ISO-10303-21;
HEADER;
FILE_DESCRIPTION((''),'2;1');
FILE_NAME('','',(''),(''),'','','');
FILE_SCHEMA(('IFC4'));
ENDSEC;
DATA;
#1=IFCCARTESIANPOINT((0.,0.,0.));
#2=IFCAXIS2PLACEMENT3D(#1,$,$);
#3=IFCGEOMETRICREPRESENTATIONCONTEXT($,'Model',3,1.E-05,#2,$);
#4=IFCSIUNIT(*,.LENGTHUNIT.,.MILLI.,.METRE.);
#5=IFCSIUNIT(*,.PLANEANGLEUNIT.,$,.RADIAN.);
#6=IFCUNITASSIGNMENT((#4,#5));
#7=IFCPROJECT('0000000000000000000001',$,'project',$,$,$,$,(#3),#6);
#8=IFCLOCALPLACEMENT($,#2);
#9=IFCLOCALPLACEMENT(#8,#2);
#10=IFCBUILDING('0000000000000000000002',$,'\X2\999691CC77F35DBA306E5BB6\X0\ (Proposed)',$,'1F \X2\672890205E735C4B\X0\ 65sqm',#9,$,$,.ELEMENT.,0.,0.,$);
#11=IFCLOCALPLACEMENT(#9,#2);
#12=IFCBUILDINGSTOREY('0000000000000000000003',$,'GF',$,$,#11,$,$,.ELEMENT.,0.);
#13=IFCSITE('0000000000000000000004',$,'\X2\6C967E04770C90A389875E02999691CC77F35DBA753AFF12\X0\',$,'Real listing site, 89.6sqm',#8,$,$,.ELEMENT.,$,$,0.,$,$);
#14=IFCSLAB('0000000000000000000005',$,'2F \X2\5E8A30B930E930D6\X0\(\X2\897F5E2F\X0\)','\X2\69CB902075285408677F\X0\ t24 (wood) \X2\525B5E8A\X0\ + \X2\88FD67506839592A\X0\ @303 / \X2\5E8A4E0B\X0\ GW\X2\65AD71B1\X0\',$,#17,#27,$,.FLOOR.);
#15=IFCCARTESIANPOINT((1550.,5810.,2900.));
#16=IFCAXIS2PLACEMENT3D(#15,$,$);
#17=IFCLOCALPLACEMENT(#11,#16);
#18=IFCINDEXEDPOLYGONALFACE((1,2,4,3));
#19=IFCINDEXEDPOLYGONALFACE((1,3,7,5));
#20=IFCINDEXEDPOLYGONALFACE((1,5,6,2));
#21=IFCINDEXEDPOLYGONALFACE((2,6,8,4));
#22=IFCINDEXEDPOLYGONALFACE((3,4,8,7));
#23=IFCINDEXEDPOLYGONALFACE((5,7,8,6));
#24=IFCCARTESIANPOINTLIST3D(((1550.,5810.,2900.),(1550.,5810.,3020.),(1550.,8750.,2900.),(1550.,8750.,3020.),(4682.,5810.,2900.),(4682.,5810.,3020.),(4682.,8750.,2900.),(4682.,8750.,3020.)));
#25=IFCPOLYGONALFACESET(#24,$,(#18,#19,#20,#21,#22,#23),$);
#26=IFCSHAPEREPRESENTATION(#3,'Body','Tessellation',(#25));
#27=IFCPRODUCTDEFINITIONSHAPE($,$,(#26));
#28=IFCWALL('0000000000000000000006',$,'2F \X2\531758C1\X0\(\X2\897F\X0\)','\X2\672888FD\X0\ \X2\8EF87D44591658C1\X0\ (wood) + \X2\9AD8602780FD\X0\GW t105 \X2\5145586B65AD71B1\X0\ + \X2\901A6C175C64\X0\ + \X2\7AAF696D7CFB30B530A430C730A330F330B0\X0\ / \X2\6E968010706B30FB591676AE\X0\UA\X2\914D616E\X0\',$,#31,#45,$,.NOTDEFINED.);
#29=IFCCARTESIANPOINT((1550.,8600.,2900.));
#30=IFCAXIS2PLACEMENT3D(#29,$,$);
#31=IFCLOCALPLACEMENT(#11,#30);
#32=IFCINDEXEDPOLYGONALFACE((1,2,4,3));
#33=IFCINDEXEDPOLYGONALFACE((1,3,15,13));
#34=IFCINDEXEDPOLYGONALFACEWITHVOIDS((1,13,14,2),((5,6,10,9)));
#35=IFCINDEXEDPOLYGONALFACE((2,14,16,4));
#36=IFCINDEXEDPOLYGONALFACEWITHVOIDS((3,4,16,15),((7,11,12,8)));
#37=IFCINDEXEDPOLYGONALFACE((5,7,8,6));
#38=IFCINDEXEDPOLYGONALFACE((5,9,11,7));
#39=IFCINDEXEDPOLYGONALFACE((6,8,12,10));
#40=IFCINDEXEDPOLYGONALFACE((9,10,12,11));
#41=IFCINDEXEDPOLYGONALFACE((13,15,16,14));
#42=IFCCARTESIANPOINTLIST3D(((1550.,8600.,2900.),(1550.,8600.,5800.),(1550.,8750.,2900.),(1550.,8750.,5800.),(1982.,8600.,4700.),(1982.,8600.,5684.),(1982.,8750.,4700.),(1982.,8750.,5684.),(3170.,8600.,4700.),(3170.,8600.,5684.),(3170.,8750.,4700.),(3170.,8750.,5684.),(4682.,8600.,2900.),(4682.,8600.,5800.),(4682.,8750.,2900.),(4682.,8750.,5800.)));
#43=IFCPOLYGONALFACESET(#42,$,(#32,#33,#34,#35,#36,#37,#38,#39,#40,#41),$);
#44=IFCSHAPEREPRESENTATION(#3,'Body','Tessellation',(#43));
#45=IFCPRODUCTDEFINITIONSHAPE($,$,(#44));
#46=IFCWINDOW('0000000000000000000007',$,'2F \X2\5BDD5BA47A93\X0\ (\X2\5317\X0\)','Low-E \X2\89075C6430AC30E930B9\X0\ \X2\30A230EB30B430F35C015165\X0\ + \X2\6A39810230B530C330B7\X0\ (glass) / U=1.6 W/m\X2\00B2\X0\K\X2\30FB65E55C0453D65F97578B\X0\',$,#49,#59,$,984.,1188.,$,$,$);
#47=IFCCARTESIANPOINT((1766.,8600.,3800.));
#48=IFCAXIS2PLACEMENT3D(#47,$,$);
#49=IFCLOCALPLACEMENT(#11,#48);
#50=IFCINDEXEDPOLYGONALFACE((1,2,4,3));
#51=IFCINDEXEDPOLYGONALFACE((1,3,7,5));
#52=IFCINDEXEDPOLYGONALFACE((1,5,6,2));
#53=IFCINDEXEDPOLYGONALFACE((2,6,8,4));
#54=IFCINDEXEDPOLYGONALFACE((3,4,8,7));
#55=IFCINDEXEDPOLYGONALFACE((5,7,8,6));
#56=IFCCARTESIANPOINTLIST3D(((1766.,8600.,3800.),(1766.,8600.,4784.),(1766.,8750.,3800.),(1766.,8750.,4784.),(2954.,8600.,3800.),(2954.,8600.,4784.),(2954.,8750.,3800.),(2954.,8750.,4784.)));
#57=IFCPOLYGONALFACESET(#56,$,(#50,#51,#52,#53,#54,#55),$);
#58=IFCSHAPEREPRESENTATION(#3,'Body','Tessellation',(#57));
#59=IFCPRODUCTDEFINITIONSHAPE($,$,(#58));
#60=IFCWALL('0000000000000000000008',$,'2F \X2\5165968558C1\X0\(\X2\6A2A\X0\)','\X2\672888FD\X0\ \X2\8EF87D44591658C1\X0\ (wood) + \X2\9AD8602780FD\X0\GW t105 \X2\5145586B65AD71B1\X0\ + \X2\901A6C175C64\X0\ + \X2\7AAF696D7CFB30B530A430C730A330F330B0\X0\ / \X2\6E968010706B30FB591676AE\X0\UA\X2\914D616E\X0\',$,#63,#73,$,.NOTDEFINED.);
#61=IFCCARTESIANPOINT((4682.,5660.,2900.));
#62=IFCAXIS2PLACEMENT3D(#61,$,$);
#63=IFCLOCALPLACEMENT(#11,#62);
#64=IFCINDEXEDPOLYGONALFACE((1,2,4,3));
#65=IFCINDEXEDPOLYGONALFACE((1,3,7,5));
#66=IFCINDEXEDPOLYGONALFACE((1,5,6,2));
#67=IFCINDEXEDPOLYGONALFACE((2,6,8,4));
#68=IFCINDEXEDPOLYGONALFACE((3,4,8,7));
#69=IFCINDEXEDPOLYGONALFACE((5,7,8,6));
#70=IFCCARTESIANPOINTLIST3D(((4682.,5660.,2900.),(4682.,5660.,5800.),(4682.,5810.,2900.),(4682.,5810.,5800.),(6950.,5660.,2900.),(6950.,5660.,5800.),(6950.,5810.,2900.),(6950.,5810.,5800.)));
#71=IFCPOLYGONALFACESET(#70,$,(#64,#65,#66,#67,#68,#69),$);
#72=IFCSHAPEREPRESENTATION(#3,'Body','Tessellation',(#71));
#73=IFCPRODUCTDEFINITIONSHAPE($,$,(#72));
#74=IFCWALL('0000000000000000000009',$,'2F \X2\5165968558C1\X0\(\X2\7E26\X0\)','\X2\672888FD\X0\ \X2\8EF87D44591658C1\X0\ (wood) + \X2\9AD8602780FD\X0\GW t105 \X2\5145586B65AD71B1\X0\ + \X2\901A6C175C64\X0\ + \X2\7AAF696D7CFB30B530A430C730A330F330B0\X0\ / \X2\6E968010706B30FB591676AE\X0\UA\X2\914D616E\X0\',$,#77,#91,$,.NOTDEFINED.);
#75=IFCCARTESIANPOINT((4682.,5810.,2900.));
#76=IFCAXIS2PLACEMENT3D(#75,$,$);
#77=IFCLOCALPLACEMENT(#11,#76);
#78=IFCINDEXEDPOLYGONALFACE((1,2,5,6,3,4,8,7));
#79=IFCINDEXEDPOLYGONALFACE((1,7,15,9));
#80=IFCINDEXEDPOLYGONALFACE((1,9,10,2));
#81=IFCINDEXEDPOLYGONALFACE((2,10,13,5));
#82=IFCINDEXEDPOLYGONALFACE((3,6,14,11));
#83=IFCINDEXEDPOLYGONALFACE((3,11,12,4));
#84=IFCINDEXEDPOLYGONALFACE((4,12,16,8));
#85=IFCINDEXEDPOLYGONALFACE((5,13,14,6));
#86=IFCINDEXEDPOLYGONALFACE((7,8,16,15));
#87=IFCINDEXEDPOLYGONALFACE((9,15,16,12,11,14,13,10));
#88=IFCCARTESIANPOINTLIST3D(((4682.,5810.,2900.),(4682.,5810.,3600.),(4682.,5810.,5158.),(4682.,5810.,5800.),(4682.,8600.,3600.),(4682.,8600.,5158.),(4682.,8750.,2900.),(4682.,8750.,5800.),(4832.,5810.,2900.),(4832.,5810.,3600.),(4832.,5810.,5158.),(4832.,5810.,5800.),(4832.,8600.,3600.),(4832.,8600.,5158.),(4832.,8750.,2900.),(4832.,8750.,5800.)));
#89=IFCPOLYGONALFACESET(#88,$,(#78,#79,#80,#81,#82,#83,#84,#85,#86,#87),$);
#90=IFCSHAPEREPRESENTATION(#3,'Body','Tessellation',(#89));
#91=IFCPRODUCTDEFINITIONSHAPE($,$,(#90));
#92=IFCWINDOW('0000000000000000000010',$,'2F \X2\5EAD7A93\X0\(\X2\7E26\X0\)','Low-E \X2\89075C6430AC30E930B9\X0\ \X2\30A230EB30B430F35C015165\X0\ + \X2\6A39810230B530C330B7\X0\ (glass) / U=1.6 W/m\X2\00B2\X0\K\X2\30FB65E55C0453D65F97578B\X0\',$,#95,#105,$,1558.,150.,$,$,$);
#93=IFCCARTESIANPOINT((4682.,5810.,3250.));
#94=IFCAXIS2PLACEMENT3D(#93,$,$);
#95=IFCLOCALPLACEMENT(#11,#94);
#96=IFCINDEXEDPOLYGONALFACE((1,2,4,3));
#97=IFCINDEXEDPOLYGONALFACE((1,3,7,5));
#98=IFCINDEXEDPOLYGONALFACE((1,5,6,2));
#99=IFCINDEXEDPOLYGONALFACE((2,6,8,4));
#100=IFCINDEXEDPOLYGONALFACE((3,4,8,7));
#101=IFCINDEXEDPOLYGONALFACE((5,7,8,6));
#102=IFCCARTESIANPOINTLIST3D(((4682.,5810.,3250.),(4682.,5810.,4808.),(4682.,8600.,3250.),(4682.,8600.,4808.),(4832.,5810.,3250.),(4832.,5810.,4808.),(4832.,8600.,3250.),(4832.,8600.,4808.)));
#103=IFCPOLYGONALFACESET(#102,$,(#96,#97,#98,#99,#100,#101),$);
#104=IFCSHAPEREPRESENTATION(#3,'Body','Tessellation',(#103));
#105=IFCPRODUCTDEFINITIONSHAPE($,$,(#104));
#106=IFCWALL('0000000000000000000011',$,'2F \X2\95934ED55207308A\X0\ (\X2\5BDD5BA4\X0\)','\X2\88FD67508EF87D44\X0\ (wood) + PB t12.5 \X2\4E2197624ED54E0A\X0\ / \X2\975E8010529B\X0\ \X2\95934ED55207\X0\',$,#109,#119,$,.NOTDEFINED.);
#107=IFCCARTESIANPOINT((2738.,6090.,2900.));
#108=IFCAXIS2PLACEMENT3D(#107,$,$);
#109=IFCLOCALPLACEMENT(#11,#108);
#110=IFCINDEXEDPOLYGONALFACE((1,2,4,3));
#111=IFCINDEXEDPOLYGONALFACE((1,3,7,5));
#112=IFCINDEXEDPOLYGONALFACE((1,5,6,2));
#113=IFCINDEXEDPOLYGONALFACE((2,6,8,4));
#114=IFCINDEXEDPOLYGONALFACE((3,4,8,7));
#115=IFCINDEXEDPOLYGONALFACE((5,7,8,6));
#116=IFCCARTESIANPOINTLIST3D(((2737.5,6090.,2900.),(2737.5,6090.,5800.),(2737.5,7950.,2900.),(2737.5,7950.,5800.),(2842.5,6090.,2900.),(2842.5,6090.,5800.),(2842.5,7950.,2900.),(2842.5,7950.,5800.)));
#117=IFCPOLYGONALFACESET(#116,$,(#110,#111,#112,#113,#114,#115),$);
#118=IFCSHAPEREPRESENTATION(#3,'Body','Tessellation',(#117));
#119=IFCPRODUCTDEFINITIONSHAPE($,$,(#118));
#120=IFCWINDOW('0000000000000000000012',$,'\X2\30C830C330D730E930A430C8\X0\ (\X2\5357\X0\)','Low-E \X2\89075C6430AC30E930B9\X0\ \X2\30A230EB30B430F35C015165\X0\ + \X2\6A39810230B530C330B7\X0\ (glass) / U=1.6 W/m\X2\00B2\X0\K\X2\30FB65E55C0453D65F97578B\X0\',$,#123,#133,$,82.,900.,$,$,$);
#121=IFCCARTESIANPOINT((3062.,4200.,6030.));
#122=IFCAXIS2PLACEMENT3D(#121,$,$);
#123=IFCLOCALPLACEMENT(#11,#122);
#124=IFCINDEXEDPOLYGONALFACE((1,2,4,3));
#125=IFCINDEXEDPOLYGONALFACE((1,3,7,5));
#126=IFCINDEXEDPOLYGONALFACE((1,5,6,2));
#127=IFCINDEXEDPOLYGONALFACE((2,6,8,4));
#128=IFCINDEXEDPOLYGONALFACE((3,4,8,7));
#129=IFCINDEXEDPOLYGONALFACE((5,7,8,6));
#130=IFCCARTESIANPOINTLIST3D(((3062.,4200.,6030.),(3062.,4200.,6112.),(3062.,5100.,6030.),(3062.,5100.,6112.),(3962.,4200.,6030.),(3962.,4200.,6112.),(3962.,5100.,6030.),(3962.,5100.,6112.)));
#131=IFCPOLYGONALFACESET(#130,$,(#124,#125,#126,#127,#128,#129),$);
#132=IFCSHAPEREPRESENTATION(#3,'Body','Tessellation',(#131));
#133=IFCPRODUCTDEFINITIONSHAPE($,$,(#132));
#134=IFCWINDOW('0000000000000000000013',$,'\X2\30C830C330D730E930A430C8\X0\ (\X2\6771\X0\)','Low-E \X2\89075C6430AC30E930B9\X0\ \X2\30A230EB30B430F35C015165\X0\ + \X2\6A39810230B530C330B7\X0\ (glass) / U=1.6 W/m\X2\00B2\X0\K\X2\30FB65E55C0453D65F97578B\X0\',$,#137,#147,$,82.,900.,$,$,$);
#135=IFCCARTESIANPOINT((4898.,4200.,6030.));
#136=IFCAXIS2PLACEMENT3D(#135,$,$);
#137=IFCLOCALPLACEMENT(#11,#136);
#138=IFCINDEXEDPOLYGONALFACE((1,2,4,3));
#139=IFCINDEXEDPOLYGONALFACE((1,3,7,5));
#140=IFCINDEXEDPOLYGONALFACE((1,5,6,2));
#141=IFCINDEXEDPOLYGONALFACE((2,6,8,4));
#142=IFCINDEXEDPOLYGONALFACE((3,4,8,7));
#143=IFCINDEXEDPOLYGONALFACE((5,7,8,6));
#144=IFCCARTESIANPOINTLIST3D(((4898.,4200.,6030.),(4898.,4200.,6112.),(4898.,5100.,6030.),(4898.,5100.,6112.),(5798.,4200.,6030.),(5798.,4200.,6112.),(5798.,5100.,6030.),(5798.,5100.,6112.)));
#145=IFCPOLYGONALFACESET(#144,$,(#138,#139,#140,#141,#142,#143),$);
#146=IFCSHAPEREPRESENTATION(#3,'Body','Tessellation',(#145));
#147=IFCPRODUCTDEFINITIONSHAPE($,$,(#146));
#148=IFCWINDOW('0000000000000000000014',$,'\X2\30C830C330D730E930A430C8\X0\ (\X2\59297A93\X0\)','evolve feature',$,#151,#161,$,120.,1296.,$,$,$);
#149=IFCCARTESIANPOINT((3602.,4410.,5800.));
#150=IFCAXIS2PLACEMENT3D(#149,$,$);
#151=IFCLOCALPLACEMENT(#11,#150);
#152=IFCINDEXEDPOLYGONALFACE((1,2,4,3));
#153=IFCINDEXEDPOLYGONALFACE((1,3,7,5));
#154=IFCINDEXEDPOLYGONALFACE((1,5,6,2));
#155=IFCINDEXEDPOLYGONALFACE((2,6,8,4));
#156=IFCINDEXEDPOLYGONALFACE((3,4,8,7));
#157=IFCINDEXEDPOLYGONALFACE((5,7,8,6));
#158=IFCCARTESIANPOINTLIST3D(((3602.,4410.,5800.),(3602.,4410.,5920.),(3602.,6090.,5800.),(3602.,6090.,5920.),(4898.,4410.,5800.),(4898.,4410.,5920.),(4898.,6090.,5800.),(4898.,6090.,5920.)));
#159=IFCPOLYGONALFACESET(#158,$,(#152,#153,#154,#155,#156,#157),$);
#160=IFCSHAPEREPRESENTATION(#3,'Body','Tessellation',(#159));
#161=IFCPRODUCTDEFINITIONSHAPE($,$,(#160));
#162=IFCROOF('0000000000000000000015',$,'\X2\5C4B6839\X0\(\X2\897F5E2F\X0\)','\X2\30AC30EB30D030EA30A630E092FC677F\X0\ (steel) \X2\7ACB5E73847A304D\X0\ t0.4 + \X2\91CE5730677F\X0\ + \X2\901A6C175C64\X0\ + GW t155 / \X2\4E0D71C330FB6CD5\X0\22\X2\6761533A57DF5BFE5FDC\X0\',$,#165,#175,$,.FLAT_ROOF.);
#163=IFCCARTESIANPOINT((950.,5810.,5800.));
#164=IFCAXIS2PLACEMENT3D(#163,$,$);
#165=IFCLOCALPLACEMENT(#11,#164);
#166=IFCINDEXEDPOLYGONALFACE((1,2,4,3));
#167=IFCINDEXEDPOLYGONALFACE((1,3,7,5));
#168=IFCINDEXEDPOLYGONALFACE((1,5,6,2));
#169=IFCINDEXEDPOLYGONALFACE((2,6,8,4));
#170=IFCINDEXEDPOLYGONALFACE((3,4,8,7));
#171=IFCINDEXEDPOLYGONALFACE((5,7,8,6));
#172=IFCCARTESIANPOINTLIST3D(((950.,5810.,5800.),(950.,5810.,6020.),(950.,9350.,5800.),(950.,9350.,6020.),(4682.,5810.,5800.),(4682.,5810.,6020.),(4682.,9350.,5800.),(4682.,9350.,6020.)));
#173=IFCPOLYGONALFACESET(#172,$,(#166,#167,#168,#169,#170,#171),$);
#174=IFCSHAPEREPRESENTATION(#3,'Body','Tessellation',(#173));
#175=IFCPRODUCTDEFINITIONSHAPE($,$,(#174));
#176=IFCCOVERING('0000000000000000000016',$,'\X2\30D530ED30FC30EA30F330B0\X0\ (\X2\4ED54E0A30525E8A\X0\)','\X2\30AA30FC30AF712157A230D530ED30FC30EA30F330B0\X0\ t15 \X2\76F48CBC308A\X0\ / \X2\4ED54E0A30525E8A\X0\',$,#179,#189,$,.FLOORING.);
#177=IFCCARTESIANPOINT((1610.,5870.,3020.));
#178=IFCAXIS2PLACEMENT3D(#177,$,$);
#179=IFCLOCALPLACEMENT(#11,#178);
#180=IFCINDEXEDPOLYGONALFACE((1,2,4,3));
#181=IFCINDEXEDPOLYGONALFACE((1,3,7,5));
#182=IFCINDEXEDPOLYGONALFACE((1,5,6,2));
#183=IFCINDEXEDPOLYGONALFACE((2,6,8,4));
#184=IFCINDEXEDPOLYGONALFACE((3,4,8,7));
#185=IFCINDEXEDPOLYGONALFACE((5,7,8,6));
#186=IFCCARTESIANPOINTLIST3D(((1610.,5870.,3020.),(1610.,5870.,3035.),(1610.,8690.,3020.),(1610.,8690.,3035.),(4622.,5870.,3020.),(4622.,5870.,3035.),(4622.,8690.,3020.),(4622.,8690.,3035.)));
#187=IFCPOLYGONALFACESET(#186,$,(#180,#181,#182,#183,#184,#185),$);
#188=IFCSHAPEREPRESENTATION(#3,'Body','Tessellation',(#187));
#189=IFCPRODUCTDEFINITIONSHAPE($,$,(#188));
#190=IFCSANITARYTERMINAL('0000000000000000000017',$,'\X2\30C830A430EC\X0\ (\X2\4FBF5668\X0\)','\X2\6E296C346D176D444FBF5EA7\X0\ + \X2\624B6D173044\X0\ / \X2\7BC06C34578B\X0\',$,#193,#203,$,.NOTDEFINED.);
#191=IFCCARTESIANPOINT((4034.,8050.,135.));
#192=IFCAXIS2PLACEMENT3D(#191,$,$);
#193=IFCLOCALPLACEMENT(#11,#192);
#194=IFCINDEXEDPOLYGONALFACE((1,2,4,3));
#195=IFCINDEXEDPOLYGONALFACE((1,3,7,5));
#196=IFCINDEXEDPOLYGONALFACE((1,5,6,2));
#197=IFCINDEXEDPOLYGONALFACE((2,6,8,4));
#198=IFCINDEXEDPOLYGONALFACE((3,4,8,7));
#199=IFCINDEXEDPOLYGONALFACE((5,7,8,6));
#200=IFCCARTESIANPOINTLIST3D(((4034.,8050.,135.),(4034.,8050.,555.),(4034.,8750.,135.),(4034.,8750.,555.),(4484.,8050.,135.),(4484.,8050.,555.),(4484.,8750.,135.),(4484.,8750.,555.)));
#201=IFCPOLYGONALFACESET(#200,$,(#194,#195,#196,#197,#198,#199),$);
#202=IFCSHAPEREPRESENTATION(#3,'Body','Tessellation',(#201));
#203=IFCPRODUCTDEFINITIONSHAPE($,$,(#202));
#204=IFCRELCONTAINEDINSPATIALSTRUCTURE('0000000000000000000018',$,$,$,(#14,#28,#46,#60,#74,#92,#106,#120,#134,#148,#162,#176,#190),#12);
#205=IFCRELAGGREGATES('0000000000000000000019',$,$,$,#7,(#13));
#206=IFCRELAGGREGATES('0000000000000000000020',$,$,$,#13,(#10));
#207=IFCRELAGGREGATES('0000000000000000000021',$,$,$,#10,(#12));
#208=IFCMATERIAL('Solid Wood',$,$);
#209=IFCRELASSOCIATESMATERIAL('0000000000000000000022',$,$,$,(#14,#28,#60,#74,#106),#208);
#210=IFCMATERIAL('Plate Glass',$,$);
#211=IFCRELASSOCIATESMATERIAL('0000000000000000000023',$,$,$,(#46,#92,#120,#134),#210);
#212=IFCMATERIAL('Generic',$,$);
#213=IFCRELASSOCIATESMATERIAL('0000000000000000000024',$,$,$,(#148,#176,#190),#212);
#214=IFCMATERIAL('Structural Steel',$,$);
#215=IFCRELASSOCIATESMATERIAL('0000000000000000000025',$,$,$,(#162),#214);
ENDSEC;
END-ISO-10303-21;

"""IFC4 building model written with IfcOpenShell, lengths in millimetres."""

from ifc_helpers import new_model, si_unit, frame, frame_2d, origin, place, context, project, spatial, rectangle, extrude, material, element, fill, save


model = new_model("IFC4")

# Units and contexts
model_context = context("Model", 3, precision=1e-05, world=origin())
ifc_project = project(units=[si_unit("LENGTHUNIT", "METRE", prefix="MILLI"), si_unit("PLANEANGLEUNIT", "RADIAN")], contexts=[model_context])

# Site, building, storey
site_placement = place(None, origin())
site = spatial("IfcSite", under=ifc_project, at=site_placement, Name="沖縄県那覇市首里石嶺町２", ObjectType="Real listing site, 89.6sqm", CompositionType="ELEMENT", RefElevation=0.0)
building_placement = place(site_placement, origin())
building = spatial("IfcBuilding", under=site, at=building_placement, Name="首里石嶺の家 (Proposed)", ObjectType="1F 木造平屋 65sqm", CompositionType="ELEMENT", ElevationOfRefHeight=0.0, ElevationOfTerrain=0.0)
storey_placement = place(building_placement, origin())
storey = spatial("IfcBuildingStorey", under=building, at=storey_placement, Name="GF", CompositionType="ELEMENT", Elevation=0.0)

# Slab
ifc_material_1 = material(Name="Solid Wood")
slab_placement = place(storey_placement, frame((1550.0, 5810.0, 2900.0)))
element("IfcSlab", 1, at=slab_placement, inside=storey, material=ifc_material_1, Name="2F 床スラブ(西帯)", Description="構造用合板 t24 (wood) 剛床 + 製材根太 @303 / 床下 GW断熱", PredefinedType="FLOOR", context=model_context, shape_type="SweptSolid", body=[
    extrude(rectangle(XDim=3132.0, YDim=2940.0, at=frame_2d((1566.0, 1470.0))), frame((1550.0, 5810.0, 2900.0)), (0.0, 0.0, 1.0), 120.0),
])

# Wall, opening, window
wall_1_placement = place(storey_placement, frame((1550.0, 8600.0, 2900.0)))
wall_1 = element("IfcWall", 2, at=wall_1_placement, inside=storey, material=ifc_material_1, Name="2F 北壁(西)", Description="木製 軸組外壁 (wood) + 高性能GW t105 充填断熱 + 通気層 + 窯業系サイディング / 準耐火・外皮UA配慮", PredefinedType="NOTDEFINED", context=model_context, shape_type="SweptSolid", body=[
    extrude(rectangle(XDim=3132.0, YDim=150.0, at=frame_2d((1566.0, 75.0))), frame((1550.0, 8600.0, 2900.0)), (0.0, 0.0, 1.0), 2900.0),
])
opening_1_placement = place(storey_placement, frame((1766.0, 8600.0, 3800.0)))
opening_1 = element("IfcOpeningElement", 3, at=opening_1_placement, cuts=wall_1, PredefinedType="NOTDEFINED", context=model_context, shape_type="SweptSolid", body=[
    extrude(rectangle(XDim=1188.0, YDim=150.0, at=frame_2d((594.0, 75.0))), frame((1766.0, 8600.0, 3800.0)), (0.0, 0.0, 1.0), 984.0),
])
ifc_material_2 = material(Name="Plate Glass")
window_1_placement = place(storey_placement, frame((1766.0, 8600.0, 3800.0)))
window_1 = element("IfcWindow", 4, at=window_1_placement, inside=storey, material=ifc_material_2, Name="2F 寝室窓 (北)", Description="Low-E 複層ガラス アルゴン封入 + 樹脂サッシ (glass) / U=1.6 W/m²K・日射取得型", OverallHeight=984.0, OverallWidth=1188.0, context=model_context, shape_type="SweptSolid", body=[
    extrude(rectangle(XDim=1188.0, YDim=150.0, at=frame_2d((594.0, 75.0))), frame((1766.0, 8600.0, 3800.0)), (0.0, 0.0, 1.0), 984.0),
])
fill(opening_1, window_1)

# Wall
wall_2_placement = place(storey_placement, frame((4682.0, 5660.0, 2900.0)))
element("IfcWall", 5, at=wall_2_placement, inside=storey, material=ifc_material_1, Name="2F 入隅壁(横)", Description="木製 軸組外壁 (wood) + 高性能GW t105 充填断熱 + 通気層 + 窯業系サイディング / 準耐火・外皮UA配慮", PredefinedType="NOTDEFINED", context=model_context, shape_type="SweptSolid", body=[
    extrude(rectangle(XDim=2268.0, YDim=150.0, at=frame_2d((1134.0, 75.0))), frame((4682.0, 5660.0, 2900.0)), (0.0, 0.0, 1.0), 2900.0),
])

# Wall, opening, window
wall_3_placement = place(storey_placement, frame((4682.0, 5810.0, 2900.0)))
wall_3 = element("IfcWall", 6, at=wall_3_placement, inside=storey, material=ifc_material_1, Name="2F 入隅壁(縦)", Description="木製 軸組外壁 (wood) + 高性能GW t105 充填断熱 + 通気層 + 窯業系サイディング / 準耐火・外皮UA配慮", PredefinedType="NOTDEFINED", context=model_context, shape_type="SweptSolid", body=[
    extrude(rectangle(XDim=150.0, YDim=2940.0, at=frame_2d((75.0, 1470.0))), frame((4682.0, 5810.0, 2900.0)), (0.0, 0.0, 1.0), 2900.0),
])
opening_2_placement = place(storey_placement, frame((4682.0, 5810.0, 3250.0)))
opening_2 = element("IfcOpeningElement", 7, at=opening_2_placement, cuts=wall_3, PredefinedType="NOTDEFINED", context=model_context, shape_type="SweptSolid", body=[
    extrude(rectangle(XDim=150.0, YDim=2790.0, at=frame_2d((75.0, 1395.0))), frame((4682.0, 5810.0, 3250.0)), (0.0, 0.0, 1.0), 1558.0),
])
window_2_placement = place(storey_placement, frame((4682.0, 5810.0, 3250.0)))
window_2 = element("IfcWindow", 8, at=window_2_placement, inside=storey, material=ifc_material_2, Name="2F 庭窓(縦)", Description="Low-E 複層ガラス アルゴン封入 + 樹脂サッシ (glass) / U=1.6 W/m²K・日射取得型", OverallHeight=1558.0, OverallWidth=150.0, context=model_context, shape_type="SweptSolid", body=[
    extrude(rectangle(XDim=150.0, YDim=2790.0, at=frame_2d((75.0, 1395.0))), frame((4682.0, 5810.0, 3250.0)), (0.0, 0.0, 1.0), 1558.0),
])
fill(opening_2, window_2)

# Wall
wall_4_placement = place(storey_placement, frame((2738.0, 6090.0, 2900.0)))
element("IfcWall", 9, at=wall_4_placement, inside=storey, material=ifc_material_1, Name="2F 間仕切り (寝室)", Description="製材軸組 (wood) + PB t12.5 両面仕上 / 非耐力 間仕切", PredefinedType="NOTDEFINED", context=model_context, shape_type="SweptSolid", body=[
    extrude(rectangle(XDim=105.0, YDim=1860.0, at=frame_2d((52.0, 930.0))), frame((2738.0, 6090.0, 2900.0)), (0.0, 0.0, 1.0), 2900.0),
])

# Windows
window_3_placement = place(storey_placement, frame((3062.0, 4200.0, 6030.0)))
element("IfcWindow", 10, at=window_3_placement, inside=storey, material=ifc_material_2, Name="トップライト (南)", Description="Low-E 複層ガラス アルゴン封入 + 樹脂サッシ (glass) / U=1.6 W/m²K・日射取得型", OverallHeight=82.0, OverallWidth=900.0, context=model_context, shape_type="SweptSolid", body=[
    extrude(rectangle(XDim=900.0, YDim=900.0, at=frame_2d((450.0, 450.0))), frame((3062.0, 4200.0, 6030.0)), (0.0, 0.0, 1.0), 82.0),
])
window_4_placement = place(storey_placement, frame((4898.0, 4200.0, 6030.0)))
element("IfcWindow", 11, at=window_4_placement, inside=storey, material=ifc_material_2, Name="トップライト (東)", Description="Low-E 複層ガラス アルゴン封入 + 樹脂サッシ (glass) / U=1.6 W/m²K・日射取得型", OverallHeight=82.0, OverallWidth=900.0, context=model_context, shape_type="SweptSolid", body=[
    extrude(rectangle(XDim=900.0, YDim=900.0, at=frame_2d((450.0, 450.0))), frame((4898.0, 4200.0, 6030.0)), (0.0, 0.0, 1.0), 82.0),
])
ifc_material_3 = material(Name="Generic")
window_5_placement = place(storey_placement, frame((3602.0, 4410.0, 5800.0)))
element("IfcWindow", 12, at=window_5_placement, inside=storey, material=ifc_material_3, Name="トップライト (天窓)", Description="evolve feature", OverallHeight=120.0, OverallWidth=1296.0, context=model_context, shape_type="SweptSolid", body=[
    extrude(rectangle(XDim=1296.0, YDim=1680.0, at=frame_2d((648.0, 840.0))), frame((3602.0, 4410.0, 5800.0)), (0.0, 0.0, 1.0), 120.0),
])

# Roof
ifc_material_4 = material(Name="Structural Steel")
for number, where, name in (
    (13, (950.0, 5810.0, 5800.0), "屋根(西帯)"),
):
    element("IfcRoof", number, at=place(storey_placement, frame(where)), inside=storey, material=ifc_material_4, Name=name, Description="ガルバリウム鋼板 (steel) 立平葺き t0.4 + 野地板 + 通気層 + GW t155 / 不燃・法22条区域対応", PredefinedType="FLAT_ROOF", context=model_context, shape_type="SweptSolid", body=[
        extrude(rectangle(XDim=3732.0, YDim=3540.0, at=frame_2d((1866.0, 1770.0))), frame((950.0, 5810.0, 5800.0)), (0.0, 0.0, 1.0), 220.0),
    ])

# Covering
covering_placement = place(storey_placement, frame((1610.0, 5870.0, 3020.0)))
element("IfcCovering", 14, at=covering_placement, inside=storey, material=ifc_material_3, Name="フローリング (仕上げ床)", Description="オーク無垢フローリング t15 直貼り / 仕上げ床", PredefinedType="FLOORING", context=model_context, shape_type="SweptSolid", body=[
    extrude(rectangle(XDim=3012.0, YDim=2820.0, at=frame_2d((1506.0, 1410.0))), frame((1610.0, 5870.0, 3020.0)), (0.0, 0.0, 1.0), 15.0),
])

# Sanitary terminal
sanitary_terminal_placement = place(storey_placement, frame((4034.0, 8050.0, 135.0)))
element("IfcSanitaryTerminal", 15, at=sanitary_terminal_placement, inside=storey, material=ifc_material_3, Name="トイレ (便器)", Description="温水洗浄便座 + 手洗い / 節水型", PredefinedType="NOTDEFINED", context=model_context, shape_type="SweptSolid", body=[
    extrude(rectangle(XDim=450.0, YDim=700.0, at=frame_2d((225.0, 350.0))), frame((4034.0, 8050.0, 135.0)), (0.0, 0.0, 1.0), 420.0),
])

save(model, "model.ifc")
